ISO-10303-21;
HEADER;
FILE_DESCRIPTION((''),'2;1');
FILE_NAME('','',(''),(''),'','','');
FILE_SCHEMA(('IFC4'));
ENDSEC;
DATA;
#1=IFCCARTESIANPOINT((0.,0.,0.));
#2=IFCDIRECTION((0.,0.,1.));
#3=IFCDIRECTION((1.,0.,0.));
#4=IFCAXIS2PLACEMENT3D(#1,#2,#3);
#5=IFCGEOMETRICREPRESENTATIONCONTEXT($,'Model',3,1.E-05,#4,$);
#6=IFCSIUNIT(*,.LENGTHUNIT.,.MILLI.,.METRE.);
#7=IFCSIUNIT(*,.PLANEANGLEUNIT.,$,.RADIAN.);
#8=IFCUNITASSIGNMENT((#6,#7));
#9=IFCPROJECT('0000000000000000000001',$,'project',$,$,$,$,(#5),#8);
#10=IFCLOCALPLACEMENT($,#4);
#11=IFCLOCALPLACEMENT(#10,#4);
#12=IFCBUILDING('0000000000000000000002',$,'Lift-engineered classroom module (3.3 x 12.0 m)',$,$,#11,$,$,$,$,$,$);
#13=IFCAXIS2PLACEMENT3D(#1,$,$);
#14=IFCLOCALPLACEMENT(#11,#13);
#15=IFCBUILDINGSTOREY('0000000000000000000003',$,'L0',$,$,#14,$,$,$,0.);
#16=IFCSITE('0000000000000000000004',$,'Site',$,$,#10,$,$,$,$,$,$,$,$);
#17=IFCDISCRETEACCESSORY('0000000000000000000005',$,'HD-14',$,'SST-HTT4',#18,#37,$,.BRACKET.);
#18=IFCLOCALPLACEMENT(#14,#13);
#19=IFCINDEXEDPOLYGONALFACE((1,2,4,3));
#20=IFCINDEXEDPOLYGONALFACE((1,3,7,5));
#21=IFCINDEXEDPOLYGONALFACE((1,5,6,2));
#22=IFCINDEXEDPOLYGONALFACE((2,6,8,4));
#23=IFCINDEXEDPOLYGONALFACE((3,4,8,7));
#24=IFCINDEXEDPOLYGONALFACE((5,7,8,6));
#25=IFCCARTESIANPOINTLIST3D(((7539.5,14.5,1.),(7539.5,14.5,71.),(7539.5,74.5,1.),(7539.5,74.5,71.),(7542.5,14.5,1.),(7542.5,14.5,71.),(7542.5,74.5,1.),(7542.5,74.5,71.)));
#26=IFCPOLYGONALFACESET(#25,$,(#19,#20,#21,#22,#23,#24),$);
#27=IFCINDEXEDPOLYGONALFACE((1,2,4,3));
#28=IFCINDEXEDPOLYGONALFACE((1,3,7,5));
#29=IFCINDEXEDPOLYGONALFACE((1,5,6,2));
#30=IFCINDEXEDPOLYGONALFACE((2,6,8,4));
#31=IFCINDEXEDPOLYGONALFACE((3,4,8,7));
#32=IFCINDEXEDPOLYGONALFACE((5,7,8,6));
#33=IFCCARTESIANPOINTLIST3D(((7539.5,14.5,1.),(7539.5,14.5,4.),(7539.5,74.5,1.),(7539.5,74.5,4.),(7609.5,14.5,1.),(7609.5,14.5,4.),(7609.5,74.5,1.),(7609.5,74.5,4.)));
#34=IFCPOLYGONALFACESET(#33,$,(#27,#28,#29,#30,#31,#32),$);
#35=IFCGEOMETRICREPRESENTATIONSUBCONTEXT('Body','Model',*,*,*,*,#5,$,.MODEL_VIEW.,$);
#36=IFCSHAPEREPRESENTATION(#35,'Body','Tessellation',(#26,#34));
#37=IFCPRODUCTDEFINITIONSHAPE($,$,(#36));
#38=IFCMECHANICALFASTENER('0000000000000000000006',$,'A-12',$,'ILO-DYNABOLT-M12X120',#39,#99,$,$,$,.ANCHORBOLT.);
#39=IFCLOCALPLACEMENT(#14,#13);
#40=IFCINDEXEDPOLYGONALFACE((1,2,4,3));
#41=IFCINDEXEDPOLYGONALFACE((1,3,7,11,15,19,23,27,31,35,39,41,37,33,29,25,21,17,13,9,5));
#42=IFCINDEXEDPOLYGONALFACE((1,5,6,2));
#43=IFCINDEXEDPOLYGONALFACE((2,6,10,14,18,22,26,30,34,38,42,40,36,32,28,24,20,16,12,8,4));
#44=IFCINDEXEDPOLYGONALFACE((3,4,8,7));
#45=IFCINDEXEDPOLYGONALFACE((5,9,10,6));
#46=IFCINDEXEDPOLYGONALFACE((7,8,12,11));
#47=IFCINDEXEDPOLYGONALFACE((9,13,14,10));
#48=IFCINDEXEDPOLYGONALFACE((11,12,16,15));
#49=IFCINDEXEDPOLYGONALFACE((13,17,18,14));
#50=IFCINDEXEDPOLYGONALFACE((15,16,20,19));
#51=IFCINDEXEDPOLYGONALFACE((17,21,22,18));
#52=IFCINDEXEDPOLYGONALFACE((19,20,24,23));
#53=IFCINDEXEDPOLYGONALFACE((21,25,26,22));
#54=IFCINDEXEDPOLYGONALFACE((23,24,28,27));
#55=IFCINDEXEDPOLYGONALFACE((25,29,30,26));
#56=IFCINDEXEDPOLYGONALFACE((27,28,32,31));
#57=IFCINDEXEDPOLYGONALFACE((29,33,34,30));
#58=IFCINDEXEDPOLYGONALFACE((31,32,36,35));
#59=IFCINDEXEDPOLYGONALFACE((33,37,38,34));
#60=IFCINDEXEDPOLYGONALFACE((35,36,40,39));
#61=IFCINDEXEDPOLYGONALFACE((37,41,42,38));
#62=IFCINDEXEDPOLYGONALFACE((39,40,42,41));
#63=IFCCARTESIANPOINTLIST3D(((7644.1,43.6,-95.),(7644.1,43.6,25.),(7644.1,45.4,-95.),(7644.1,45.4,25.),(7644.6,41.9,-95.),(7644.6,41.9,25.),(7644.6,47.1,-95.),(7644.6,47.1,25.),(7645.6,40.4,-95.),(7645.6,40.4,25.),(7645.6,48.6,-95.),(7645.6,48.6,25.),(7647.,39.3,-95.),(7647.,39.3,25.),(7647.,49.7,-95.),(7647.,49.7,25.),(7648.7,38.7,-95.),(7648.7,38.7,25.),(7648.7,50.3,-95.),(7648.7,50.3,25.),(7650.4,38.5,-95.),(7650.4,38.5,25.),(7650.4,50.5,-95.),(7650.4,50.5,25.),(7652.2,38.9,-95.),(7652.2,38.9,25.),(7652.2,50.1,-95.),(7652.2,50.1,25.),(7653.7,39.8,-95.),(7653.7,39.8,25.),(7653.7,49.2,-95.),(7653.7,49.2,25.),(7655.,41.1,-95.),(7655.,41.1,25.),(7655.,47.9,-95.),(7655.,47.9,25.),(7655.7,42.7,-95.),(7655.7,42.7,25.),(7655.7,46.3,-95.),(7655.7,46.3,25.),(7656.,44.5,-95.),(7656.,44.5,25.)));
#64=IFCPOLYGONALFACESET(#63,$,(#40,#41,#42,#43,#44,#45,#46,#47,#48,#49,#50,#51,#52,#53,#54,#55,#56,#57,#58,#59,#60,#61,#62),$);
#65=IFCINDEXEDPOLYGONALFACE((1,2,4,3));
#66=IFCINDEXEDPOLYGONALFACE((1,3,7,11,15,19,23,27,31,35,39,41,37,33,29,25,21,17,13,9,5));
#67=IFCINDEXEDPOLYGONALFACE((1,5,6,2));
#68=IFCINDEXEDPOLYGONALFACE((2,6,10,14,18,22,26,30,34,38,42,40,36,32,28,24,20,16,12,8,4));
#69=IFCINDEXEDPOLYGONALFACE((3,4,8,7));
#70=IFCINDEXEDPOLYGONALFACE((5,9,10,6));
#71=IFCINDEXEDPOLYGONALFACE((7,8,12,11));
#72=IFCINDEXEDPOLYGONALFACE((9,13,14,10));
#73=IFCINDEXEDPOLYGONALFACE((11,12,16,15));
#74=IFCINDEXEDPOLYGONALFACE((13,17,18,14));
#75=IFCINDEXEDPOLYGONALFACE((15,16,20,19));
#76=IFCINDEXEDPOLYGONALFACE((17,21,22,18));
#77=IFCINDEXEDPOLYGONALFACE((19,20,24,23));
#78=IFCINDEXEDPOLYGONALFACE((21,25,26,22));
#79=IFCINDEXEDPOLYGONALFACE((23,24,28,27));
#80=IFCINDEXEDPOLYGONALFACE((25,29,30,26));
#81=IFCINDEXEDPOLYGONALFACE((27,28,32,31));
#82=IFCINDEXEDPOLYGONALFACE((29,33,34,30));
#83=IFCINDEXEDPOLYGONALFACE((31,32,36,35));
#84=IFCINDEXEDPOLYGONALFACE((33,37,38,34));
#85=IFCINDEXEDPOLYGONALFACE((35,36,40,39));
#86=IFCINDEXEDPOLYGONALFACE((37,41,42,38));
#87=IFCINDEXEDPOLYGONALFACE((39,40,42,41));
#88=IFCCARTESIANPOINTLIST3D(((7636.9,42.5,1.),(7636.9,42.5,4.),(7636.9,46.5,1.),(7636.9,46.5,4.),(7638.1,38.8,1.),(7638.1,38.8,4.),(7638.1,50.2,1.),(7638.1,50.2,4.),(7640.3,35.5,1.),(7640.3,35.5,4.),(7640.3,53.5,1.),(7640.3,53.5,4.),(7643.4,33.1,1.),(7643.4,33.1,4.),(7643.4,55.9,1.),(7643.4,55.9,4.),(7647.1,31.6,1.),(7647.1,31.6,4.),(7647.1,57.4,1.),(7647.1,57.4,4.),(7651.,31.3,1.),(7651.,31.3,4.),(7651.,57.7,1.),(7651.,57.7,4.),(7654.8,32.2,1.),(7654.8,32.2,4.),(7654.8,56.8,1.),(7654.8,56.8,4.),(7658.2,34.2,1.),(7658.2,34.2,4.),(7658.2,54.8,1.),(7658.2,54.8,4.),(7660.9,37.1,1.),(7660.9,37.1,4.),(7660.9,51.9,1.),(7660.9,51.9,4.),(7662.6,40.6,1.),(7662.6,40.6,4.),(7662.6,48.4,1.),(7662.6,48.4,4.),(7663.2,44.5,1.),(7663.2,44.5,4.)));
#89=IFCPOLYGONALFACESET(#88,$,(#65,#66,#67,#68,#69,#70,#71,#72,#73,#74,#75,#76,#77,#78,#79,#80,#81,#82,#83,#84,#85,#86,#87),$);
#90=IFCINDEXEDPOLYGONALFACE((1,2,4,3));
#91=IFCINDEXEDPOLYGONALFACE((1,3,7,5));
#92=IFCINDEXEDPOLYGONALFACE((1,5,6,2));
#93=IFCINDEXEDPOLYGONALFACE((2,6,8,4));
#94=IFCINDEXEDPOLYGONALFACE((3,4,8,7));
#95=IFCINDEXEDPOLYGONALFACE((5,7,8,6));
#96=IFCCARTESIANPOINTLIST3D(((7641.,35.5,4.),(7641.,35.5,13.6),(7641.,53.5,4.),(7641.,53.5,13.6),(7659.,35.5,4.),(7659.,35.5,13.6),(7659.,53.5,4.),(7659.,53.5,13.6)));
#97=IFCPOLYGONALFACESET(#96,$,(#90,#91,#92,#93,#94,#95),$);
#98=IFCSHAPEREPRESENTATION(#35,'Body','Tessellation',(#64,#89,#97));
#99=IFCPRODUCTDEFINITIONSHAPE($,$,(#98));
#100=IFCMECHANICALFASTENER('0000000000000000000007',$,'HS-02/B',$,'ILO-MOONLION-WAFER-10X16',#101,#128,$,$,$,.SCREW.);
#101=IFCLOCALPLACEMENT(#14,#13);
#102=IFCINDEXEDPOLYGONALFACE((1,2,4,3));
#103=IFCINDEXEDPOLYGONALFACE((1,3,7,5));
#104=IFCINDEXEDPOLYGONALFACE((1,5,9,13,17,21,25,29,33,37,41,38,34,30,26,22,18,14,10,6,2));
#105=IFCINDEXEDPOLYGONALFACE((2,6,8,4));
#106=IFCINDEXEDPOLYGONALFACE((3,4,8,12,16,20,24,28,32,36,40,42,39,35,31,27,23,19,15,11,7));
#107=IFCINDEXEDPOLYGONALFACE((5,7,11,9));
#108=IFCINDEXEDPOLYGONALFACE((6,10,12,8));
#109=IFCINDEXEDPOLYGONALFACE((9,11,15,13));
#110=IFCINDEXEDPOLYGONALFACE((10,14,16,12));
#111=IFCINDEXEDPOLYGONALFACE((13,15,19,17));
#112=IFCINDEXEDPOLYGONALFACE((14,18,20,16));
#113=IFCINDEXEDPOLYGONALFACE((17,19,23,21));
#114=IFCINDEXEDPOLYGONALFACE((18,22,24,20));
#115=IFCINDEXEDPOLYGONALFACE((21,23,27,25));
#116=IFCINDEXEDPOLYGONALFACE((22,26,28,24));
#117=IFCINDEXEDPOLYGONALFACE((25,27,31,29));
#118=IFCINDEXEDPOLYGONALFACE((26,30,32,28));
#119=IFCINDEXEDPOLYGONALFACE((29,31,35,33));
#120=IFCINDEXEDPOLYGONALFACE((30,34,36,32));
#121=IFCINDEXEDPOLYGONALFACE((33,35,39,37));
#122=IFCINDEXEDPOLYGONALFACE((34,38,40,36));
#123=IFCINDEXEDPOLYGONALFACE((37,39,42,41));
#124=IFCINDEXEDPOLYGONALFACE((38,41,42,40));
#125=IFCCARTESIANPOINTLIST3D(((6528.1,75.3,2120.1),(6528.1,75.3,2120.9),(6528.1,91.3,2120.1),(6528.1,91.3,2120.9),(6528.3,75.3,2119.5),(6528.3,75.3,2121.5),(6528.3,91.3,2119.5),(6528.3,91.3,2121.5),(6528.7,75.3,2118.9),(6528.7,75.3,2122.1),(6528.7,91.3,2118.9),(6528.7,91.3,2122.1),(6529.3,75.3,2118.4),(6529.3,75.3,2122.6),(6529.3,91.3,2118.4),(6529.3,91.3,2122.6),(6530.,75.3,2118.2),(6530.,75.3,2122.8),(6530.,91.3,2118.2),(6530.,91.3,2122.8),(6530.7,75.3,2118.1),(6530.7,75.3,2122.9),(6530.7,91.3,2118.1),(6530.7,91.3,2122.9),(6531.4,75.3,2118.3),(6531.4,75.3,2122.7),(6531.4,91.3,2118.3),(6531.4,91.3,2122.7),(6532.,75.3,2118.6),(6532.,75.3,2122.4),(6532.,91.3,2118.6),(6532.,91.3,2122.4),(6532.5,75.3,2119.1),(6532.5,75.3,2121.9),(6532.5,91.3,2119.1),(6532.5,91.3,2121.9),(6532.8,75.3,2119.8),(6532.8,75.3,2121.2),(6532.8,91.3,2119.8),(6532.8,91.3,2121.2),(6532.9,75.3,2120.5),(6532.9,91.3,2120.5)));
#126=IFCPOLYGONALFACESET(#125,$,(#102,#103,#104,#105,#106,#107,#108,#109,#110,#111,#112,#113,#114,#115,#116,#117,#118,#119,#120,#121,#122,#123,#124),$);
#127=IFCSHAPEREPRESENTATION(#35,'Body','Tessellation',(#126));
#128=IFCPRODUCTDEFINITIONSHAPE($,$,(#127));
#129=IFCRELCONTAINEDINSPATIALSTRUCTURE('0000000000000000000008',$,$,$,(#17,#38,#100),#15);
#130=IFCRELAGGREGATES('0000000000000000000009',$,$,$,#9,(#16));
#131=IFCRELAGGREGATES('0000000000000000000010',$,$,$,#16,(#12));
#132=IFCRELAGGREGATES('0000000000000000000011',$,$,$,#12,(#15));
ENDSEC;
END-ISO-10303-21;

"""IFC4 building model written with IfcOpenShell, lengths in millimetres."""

from ifc_helpers import new_model, si_unit, frame, frame_2d, origin, origin_with_axes, origin_2d, place, context, subcontext, project, spatial, rectangle, circle, extrude, element, save


model = new_model("IFC4")

# Units and contexts
model_context = context("Model", 3, precision=1e-05, world=origin_with_axes())
body_context = subcontext(model_context, "Body", "Model", "MODEL_VIEW")
ifc_project = project(units=[si_unit("LENGTHUNIT", "METRE", prefix="MILLI"), si_unit("PLANEANGLEUNIT", "RADIAN")], contexts=[model_context])

# Site, building, storey
site_placement = place(None, origin_with_axes())
site = spatial("IfcSite", under=ifc_project, at=site_placement, Name="Site")
building_placement = place(site_placement, origin_with_axes())
building = spatial("IfcBuilding", under=site, at=building_placement, Name="Lift-engineered classroom module (3.3 x 12.0 m)")
storey_placement = place(building_placement, origin())
storey = spatial("IfcBuildingStorey", under=building, at=storey_placement, Name="L0", Elevation=0.0)

# Discrete accessory
for number, where, z_axis, x_axis, name in (
    (1, (7539.5, 44.5, 0.0), (0.0, 0.0, 1.0), (1.0, 0.0, 0.0), "HD-14"),
):
    element("IfcDiscreteAccessory", number, at=place(None, frame(where, z_axis=z_axis, x_axis=x_axis)), inside=storey, Name=name, ObjectType="SST-HTT4", PredefinedType="BRACKET", context=body_context, shape_type="SweptSolid", body=[
        extrude(rectangle(XDim=3.0, YDim=60.0, at=frame_2d((1.5, 0.0))), frame((0.0, 0.0, 1.0), z_axis=(0.0, 0.0, 1.0), x_axis=(1.0, 0.0, 0.0)), (0.0, 0.0, 1.0), 70.0),
        extrude(rectangle(XDim=70.0, YDim=60.0, at=frame_2d((35.0, 0.0))), frame((0.0, 0.0, 1.0), z_axis=(0.0, 0.0, 1.0), x_axis=(1.0, 0.0, 0.0)), (0.0, 0.0, 1.0), 3.0),
    ])

# Mechanical fasteners
mechanical_fastener_1_placement = place(None, frame((7650.0, 44.5, 0.0), z_axis=(0.0, 0.0, 1.0), x_axis=(1.0, 0.0, 0.0)))
element("IfcMechanicalFastener", 2, at=mechanical_fastener_1_placement, inside=storey, Name="A-12", ObjectType="ILO-DYNABOLT-M12X120", PredefinedType="ANCHORBOLT", context=body_context, shape_type="SweptSolid", body=[
    extrude(circle(Radius=6.0, at=origin_2d()), frame((0.0, 0.0, -95.0), z_axis=(0.0, 0.0, 1.0), x_axis=(1.0, 0.0, 0.0)), (0.0, 0.0, 1.0), 120.0),
    extrude(circle(Radius=13.2, at=origin_2d()), frame((0.0, 0.0, 1.0), z_axis=(0.0, 0.0, 1.0), x_axis=(1.0, 0.0, 0.0)), (0.0, 0.0, 1.0), 3.0),
    extrude(rectangle(XDim=18.0, YDim=18.0, at=origin_2d()), frame((0.0, 0.0, 4.0), z_axis=(0.0, 0.0, 1.0), x_axis=(1.0, 0.0, 0.0)), (0.0, 0.0, 1.0), 9.6),
])
mechanical_fastener_2_placement = place(None, frame((6530.5, 89.8, 2120.5), z_axis=(0.0, -1.0, 0.0), x_axis=(1.0, 0.0, 0.0)))
element("IfcMechanicalFastener", 3, at=mechanical_fastener_2_placement, inside=storey, Name="HS-02/B", ObjectType="ILO-MOONLION-WAFER-10X16", PredefinedType="SCREW", context=body_context, shape_type="SweptSolid", body=[
    extrude(circle(Radius=2.4, at=origin_2d()), frame((0.0, 0.0, -1.5), z_axis=(0.0, 0.0, 1.0), x_axis=(1.0, 0.0, 0.0)), (0.0, 0.0, 1.0), 16.0),
])

save(model, "model.ifc")
